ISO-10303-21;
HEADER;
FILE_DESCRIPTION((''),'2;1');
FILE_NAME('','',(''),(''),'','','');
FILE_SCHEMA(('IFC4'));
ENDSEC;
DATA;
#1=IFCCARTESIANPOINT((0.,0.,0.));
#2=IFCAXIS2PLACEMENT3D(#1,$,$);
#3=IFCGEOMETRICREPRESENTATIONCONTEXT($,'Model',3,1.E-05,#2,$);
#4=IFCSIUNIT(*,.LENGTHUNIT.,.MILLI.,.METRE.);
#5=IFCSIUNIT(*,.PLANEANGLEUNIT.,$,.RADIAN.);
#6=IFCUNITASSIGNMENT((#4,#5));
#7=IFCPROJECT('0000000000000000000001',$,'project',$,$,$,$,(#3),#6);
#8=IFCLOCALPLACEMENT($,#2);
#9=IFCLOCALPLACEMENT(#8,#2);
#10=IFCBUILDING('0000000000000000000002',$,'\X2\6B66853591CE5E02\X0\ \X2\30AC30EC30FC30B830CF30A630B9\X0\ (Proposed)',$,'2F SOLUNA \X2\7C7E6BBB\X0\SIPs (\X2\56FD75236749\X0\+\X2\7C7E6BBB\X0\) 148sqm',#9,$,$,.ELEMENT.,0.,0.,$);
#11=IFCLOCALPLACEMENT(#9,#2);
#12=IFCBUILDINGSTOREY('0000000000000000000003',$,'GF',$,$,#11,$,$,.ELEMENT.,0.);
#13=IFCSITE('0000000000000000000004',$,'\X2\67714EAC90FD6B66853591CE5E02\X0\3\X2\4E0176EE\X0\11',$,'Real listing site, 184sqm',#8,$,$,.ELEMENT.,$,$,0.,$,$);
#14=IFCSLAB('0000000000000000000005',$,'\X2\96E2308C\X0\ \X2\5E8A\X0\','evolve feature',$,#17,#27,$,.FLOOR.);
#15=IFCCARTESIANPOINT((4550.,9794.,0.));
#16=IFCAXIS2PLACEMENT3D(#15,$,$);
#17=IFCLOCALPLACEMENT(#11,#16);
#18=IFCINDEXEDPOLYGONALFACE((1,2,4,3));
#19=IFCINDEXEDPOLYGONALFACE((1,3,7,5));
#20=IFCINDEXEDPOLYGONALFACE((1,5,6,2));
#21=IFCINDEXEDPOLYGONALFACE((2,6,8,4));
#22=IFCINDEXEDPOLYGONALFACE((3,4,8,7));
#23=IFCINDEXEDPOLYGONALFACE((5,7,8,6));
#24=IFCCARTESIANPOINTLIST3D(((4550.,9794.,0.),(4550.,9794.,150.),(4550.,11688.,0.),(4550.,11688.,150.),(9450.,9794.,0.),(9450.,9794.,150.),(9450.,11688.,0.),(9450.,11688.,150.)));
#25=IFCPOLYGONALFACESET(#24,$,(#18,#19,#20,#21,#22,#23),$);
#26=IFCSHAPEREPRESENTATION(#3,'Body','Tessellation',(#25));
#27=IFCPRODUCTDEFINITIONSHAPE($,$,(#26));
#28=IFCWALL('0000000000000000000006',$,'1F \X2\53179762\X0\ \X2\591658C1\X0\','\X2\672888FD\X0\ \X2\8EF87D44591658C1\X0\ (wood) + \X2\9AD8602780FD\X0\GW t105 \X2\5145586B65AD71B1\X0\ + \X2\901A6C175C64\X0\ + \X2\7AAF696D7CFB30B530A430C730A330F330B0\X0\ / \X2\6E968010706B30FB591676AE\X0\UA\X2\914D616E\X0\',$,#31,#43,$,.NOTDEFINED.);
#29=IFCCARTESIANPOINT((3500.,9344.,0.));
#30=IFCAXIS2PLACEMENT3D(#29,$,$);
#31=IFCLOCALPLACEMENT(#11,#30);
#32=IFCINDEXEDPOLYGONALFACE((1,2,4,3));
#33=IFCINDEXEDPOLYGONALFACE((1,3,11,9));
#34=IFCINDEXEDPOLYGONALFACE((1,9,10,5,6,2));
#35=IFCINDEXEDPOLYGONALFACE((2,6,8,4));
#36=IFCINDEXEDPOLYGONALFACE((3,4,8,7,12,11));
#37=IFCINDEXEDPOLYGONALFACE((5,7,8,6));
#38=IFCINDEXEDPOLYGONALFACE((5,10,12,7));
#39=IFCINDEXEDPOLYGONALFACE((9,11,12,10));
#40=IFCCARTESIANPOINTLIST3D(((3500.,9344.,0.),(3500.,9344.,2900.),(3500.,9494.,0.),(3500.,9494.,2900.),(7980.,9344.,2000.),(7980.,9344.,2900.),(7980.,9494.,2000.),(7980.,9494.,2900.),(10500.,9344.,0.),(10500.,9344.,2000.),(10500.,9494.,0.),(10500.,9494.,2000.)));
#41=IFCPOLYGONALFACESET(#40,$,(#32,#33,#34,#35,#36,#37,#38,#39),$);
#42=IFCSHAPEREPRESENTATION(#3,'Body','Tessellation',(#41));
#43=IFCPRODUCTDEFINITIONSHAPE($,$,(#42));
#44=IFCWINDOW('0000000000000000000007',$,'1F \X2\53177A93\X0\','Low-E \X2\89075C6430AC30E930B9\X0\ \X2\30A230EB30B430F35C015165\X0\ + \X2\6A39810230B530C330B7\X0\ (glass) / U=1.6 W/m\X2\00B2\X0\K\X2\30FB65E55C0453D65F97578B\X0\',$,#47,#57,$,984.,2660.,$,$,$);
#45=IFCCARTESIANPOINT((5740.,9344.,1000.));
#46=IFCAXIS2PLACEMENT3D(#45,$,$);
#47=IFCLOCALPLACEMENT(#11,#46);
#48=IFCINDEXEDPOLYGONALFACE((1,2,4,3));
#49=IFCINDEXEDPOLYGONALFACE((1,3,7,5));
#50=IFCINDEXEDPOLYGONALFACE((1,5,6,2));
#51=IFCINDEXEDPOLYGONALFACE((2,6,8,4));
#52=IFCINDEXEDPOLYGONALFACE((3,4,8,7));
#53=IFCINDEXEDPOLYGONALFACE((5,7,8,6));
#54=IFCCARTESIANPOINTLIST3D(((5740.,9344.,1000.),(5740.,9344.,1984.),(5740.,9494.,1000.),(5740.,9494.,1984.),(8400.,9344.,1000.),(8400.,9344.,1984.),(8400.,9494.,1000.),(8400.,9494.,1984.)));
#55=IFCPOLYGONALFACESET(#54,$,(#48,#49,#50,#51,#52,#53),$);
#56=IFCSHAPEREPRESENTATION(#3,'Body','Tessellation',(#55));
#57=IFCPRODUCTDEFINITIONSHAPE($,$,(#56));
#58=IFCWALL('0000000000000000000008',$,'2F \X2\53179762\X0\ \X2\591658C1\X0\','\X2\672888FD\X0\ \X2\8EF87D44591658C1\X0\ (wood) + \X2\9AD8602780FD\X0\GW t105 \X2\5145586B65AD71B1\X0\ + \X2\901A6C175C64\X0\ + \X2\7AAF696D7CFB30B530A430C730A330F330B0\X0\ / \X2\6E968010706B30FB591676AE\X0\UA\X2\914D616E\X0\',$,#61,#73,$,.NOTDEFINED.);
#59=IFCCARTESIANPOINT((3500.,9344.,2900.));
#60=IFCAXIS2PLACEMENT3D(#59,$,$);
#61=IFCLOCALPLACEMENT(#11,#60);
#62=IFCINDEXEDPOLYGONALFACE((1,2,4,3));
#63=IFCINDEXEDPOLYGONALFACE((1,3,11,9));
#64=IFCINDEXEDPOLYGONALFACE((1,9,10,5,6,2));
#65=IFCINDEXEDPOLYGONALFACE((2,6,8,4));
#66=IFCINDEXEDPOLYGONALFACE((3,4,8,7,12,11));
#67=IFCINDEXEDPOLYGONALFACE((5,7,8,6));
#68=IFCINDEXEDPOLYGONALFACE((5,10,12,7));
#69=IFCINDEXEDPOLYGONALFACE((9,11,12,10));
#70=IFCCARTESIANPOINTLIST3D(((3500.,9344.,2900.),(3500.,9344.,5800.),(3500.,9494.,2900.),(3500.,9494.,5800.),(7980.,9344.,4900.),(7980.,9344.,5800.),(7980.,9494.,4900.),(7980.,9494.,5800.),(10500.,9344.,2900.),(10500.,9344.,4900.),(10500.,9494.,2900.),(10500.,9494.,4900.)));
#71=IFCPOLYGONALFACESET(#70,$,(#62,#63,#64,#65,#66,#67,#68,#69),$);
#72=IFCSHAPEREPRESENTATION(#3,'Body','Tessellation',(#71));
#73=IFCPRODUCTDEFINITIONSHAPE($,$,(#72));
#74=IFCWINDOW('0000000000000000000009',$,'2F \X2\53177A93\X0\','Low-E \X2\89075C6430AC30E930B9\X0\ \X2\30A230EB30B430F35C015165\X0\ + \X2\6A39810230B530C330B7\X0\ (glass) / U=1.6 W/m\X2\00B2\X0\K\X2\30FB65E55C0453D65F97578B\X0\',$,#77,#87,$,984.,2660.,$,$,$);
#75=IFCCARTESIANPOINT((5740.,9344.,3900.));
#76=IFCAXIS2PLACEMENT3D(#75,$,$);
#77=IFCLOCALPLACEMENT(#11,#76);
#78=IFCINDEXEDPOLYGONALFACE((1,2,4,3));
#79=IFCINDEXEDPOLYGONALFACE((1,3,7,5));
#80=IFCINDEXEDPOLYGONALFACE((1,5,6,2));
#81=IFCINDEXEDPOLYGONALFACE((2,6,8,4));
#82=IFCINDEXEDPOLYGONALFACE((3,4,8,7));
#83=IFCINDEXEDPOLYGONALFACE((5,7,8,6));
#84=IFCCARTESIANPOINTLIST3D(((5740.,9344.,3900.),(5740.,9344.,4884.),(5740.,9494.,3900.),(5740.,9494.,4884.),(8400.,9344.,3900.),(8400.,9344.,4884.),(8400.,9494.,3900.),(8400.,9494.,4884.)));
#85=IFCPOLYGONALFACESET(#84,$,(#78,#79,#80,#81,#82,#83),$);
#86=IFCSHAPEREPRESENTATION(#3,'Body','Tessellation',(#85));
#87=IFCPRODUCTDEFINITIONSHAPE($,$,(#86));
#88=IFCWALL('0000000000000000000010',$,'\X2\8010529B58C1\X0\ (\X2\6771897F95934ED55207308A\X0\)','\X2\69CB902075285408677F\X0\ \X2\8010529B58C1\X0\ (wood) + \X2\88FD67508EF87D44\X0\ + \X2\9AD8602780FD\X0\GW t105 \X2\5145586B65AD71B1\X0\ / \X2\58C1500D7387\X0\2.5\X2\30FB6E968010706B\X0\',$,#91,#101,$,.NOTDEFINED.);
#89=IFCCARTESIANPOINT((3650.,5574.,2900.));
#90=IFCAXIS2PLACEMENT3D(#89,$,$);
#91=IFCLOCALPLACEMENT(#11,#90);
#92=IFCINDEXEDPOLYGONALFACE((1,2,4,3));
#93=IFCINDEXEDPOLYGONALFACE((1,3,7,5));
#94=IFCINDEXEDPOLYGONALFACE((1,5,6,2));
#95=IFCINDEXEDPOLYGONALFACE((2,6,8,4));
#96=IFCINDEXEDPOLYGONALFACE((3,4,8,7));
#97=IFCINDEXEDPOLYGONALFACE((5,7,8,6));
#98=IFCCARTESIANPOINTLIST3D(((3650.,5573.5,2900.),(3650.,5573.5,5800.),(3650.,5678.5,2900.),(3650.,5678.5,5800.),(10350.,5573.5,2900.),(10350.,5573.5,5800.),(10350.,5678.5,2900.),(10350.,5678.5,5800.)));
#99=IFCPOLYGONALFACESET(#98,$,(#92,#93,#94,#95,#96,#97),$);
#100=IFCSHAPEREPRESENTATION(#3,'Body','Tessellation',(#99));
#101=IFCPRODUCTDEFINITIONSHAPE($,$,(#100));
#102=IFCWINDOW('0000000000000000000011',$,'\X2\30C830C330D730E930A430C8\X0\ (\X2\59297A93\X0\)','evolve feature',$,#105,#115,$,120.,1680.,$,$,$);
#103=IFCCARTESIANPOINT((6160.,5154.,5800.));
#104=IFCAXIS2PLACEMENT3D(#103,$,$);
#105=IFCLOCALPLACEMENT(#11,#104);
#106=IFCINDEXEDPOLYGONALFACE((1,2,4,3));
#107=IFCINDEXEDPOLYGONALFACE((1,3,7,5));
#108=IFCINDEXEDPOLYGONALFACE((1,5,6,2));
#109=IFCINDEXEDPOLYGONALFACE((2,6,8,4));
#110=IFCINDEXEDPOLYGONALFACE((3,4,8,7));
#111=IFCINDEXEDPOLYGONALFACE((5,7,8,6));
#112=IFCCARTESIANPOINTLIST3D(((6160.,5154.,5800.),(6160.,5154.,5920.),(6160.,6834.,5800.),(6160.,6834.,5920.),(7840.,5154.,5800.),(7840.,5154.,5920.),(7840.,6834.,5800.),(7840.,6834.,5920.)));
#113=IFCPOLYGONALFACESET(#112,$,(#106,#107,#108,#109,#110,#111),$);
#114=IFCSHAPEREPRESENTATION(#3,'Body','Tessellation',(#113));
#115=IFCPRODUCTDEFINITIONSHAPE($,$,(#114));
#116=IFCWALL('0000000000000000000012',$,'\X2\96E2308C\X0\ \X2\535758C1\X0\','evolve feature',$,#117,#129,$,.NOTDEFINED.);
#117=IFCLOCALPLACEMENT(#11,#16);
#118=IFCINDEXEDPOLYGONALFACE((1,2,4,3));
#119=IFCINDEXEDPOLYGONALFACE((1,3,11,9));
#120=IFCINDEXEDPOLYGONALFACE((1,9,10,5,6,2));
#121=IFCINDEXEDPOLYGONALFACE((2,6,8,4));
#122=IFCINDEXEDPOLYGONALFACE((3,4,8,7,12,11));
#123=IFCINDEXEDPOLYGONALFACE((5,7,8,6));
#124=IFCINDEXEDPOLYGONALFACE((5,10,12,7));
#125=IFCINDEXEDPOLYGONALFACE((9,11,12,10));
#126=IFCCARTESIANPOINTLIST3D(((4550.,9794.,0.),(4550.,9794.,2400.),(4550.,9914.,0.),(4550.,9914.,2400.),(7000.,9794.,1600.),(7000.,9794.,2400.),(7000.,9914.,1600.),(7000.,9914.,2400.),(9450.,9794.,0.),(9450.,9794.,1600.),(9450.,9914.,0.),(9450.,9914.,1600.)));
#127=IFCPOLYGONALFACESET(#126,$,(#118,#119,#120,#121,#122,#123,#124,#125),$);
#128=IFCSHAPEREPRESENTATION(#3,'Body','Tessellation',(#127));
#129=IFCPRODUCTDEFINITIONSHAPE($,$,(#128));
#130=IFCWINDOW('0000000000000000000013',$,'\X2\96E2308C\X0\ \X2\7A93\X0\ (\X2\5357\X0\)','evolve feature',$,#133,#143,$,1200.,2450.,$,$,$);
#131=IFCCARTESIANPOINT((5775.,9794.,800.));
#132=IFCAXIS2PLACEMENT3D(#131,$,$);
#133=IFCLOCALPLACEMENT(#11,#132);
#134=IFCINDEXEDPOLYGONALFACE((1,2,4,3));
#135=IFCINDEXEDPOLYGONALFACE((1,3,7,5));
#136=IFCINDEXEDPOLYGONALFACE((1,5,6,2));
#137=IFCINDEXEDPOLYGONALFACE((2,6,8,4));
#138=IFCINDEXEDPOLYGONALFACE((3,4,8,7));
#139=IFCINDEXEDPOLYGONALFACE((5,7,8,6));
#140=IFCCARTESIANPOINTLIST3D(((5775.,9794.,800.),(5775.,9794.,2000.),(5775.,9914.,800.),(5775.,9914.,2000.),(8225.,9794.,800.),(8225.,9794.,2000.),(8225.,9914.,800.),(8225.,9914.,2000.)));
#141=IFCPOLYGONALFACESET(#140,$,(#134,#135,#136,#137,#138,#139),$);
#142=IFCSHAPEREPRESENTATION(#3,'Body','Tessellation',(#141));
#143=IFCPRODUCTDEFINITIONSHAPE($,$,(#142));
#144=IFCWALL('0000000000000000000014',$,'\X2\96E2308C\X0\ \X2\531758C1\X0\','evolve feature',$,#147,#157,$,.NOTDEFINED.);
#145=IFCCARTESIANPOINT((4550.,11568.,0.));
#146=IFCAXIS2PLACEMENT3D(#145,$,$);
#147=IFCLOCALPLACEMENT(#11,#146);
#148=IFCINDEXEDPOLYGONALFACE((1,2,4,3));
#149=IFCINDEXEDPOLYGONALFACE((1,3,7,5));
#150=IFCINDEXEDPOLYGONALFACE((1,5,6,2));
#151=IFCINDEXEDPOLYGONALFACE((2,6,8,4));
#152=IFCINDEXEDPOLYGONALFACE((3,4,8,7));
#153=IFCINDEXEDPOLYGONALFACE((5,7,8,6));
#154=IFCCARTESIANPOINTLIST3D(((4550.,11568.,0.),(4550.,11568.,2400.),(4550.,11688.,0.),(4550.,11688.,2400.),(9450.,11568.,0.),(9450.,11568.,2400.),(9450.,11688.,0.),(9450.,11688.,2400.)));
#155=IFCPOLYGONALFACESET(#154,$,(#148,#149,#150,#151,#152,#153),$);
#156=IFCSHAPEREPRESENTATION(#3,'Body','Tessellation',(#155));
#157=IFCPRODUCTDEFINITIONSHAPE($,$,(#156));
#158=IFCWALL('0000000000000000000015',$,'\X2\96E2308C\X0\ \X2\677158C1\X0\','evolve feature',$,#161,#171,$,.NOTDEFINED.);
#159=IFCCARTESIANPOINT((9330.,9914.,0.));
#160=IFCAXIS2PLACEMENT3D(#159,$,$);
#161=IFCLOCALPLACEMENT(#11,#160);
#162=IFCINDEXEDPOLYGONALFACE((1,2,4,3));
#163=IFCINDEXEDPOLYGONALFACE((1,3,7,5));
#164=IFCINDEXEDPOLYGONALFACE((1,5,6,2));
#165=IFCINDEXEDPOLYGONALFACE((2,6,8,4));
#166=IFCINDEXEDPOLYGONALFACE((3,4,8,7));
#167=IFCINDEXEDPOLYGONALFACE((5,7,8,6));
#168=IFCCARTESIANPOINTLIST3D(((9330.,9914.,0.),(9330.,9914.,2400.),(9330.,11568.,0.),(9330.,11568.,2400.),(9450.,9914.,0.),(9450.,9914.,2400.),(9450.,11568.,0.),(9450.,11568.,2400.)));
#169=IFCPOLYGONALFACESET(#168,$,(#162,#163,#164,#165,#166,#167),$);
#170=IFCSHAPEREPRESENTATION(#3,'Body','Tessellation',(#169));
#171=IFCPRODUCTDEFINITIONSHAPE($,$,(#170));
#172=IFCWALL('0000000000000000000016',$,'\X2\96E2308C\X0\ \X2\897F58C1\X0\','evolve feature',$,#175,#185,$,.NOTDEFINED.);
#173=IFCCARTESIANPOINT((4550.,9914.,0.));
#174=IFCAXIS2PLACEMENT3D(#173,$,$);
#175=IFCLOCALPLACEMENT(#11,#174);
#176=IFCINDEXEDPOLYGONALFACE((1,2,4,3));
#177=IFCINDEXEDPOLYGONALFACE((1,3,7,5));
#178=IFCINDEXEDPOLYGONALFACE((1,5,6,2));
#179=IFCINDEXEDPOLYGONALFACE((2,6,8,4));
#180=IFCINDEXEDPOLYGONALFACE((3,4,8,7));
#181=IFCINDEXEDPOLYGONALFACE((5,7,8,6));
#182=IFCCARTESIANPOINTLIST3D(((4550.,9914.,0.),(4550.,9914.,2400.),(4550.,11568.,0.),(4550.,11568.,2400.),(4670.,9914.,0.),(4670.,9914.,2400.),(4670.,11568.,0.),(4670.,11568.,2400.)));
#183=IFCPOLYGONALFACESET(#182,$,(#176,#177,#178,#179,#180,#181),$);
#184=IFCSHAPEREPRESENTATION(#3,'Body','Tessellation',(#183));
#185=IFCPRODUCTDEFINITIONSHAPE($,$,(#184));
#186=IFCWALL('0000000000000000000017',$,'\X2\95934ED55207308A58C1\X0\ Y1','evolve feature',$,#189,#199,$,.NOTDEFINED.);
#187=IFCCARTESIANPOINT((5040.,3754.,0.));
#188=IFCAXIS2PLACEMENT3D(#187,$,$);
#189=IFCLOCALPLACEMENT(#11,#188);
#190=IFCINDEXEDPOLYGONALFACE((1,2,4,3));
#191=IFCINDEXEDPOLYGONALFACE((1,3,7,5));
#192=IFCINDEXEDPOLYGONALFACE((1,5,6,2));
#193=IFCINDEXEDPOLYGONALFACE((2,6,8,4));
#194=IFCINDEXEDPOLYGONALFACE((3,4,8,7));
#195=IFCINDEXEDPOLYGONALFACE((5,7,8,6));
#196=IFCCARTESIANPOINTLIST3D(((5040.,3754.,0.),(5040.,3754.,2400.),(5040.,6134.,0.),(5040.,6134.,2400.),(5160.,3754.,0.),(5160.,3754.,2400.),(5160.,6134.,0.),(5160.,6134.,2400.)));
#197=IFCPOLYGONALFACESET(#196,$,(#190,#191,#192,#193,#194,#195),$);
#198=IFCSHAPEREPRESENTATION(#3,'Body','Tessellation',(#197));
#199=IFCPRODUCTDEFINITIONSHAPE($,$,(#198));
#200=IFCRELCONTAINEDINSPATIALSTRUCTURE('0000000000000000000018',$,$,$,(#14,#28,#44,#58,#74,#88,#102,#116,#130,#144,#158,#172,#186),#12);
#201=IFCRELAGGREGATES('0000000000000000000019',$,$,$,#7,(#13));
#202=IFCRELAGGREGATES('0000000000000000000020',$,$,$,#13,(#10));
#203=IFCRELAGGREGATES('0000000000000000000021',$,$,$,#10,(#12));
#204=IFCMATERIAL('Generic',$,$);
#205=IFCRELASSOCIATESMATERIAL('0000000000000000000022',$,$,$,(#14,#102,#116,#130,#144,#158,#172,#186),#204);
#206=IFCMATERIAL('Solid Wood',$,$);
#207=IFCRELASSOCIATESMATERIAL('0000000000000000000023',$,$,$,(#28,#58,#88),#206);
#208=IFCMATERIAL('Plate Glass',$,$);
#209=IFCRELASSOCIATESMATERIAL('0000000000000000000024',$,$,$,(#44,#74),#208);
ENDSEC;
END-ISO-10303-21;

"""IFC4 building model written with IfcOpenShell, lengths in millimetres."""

from ifc_helpers import new_model, si_unit, frame, frame_2d, origin, place, context, project, spatial, rectangle, extrude, material, element, fill, save


model = new_model("IFC4")

# Units and contexts
model_context = context("Model", 3, precision=1e-05, world=origin())
ifc_project = project(units=[si_unit("LENGTHUNIT", "METRE", prefix="MILLI"), si_unit("PLANEANGLEUNIT", "RADIAN")], contexts=[model_context])

# Site, building, storey
site_placement = place(None, origin())
site = spatial("IfcSite", under=ifc_project, at=site_placement, Name="東京都武蔵野市3丁目11", ObjectType="Real listing site, 184sqm", CompositionType="ELEMENT", RefElevation=0.0)
building_placement = place(site_placement, origin())
building = spatial("IfcBuilding", under=site, at=building_placement, Name="武蔵野市 ガレージハウス (Proposed)", ObjectType="2F SOLUNA 籾殻SIPs (国産杉+籾殻) 148sqm", CompositionType="ELEMENT", ElevationOfRefHeight=0.0, ElevationOfTerrain=0.0)
storey_placement = place(building_placement, origin())
storey = spatial("IfcBuildingStorey", under=building, at=storey_placement, Name="GF", CompositionType="ELEMENT", Elevation=0.0)

# Slab
ifc_material_1 = material(Name="Generic")
slab_placement = place(storey_placement, frame((4550.0, 9794.0, 0.0)))
element("IfcSlab", 1, at=slab_placement, inside=storey, material=ifc_material_1, Name="離れ 床", Description="evolve feature", PredefinedType="FLOOR", context=model_context, shape_type="SweptSolid", body=[
    extrude(rectangle(XDim=4900.0, YDim=1894.0, at=frame_2d((2450.0, 947.0))), frame((4550.0, 9794.0, 0.0)), (0.0, 0.0, 1.0), 150.0),
])

# Wall, opening, window
ifc_material_2 = material(Name="Solid Wood")
wall_1_placement = place(storey_placement, frame((3500.0, 9344.0, 0.0)))
wall_1 = element("IfcWall", 2, at=wall_1_placement, inside=storey, material=ifc_material_2, Name="1F 北面 外壁", Description="木製 軸組外壁 (wood) + 高性能GW t105 充填断熱 + 通気層 + 窯業系サイディング / 準耐火・外皮UA配慮", PredefinedType="NOTDEFINED", context=model_context, shape_type="SweptSolid", body=[
    extrude(rectangle(XDim=7000.0, YDim=150.0, at=frame_2d((3500.0, 75.0))), frame((3500.0, 9344.0, 0.0)), (0.0, 0.0, 1.0), 2900.0),
])
opening_1_placement = place(storey_placement, frame((5740.0, 9344.0, 1000.0)))
opening_1 = element("IfcOpeningElement", 3, at=opening_1_placement, cuts=wall_1, PredefinedType="NOTDEFINED", context=model_context, shape_type="SweptSolid", body=[
    extrude(rectangle(XDim=2660.0, YDim=150.0, at=frame_2d((1330.0, 75.0))), frame((5740.0, 9344.0, 1000.0)), (0.0, 0.0, 1.0), 984.0),
])
ifc_material_3 = material(Name="Plate Glass")
window_1_placement = place(storey_placement, frame((5740.0, 9344.0, 1000.0)))
window_1 = element("IfcWindow", 4, at=window_1_placement, inside=storey, material=ifc_material_3, Name="1F 北窓", Description="Low-E 複層ガラス アルゴン封入 + 樹脂サッシ (glass) / U=1.6 W/m²K・日射取得型", OverallHeight=984.0, OverallWidth=2660.0, context=model_context, shape_type="SweptSolid", body=[
    extrude(rectangle(XDim=2660.0, YDim=150.0, at=frame_2d((1330.0, 75.0))), frame((5740.0, 9344.0, 1000.0)), (0.0, 0.0, 1.0), 984.0),
])
fill(opening_1, window_1)

# Wall, opening, window
wall_2_placement = place(storey_placement, frame((3500.0, 9344.0, 2900.0)))
wall_2 = element("IfcWall", 5, at=wall_2_placement, inside=storey, material=ifc_material_2, Name="2F 北面 外壁", Description="木製 軸組外壁 (wood) + 高性能GW t105 充填断熱 + 通気層 + 窯業系サイディング / 準耐火・外皮UA配慮", PredefinedType="NOTDEFINED", context=model_context, shape_type="SweptSolid", body=[
    extrude(rectangle(XDim=7000.0, YDim=150.0, at=frame_2d((3500.0, 75.0))), frame((3500.0, 9344.0, 2900.0)), (0.0, 0.0, 1.0), 2900.0),
])
opening_2_placement = place(storey_placement, frame((5740.0, 9344.0, 3900.0)))
opening_2 = element("IfcOpeningElement", 6, at=opening_2_placement, cuts=wall_2, PredefinedType="NOTDEFINED", context=model_context, shape_type="SweptSolid", body=[
    extrude(rectangle(XDim=2660.0, YDim=150.0, at=frame_2d((1330.0, 75.0))), frame((5740.0, 9344.0, 3900.0)), (0.0, 0.0, 1.0), 984.0),
])
window_2_placement = place(storey_placement, frame((5740.0, 9344.0, 3900.0)))
window_2 = element("IfcWindow", 7, at=window_2_placement, inside=storey, material=ifc_material_3, Name="2F 北窓", Description="Low-E 複層ガラス アルゴン封入 + 樹脂サッシ (glass) / U=1.6 W/m²K・日射取得型", OverallHeight=984.0, OverallWidth=2660.0, context=model_context, shape_type="SweptSolid", body=[
    extrude(rectangle(XDim=2660.0, YDim=150.0, at=frame_2d((1330.0, 75.0))), frame((5740.0, 9344.0, 3900.0)), (0.0, 0.0, 1.0), 984.0),
])
fill(opening_2, window_2)

# Wall
wall_3_placement = place(storey_placement, frame((3650.0, 5574.0, 2900.0)))
element("IfcWall", 8, at=wall_3_placement, inside=storey, material=ifc_material_2, Name="耐力壁 (東西間仕切り)", Description="構造用合板 耐力壁 (wood) + 製材軸組 + 高性能GW t105 充填断熱 / 壁倍率2.5・準耐火", PredefinedType="NOTDEFINED", context=model_context, shape_type="SweptSolid", body=[
    extrude(rectangle(XDim=6700.0, YDim=105.0, at=frame_2d((3350.0, 52.0))), frame((3650.0, 5574.0, 2900.0)), (0.0, 0.0, 1.0), 2900.0),
])

# Window
window_3_placement = place(storey_placement, frame((6160.0, 5154.0, 5800.0)))
element("IfcWindow", 9, at=window_3_placement, inside=storey, material=ifc_material_1, Name="トップライト (天窓)", Description="evolve feature", OverallHeight=120.0, OverallWidth=1680.0, context=model_context, shape_type="SweptSolid", body=[
    extrude(rectangle(XDim=1680.0, YDim=1680.0, at=frame_2d((840.0, 840.0))), frame((6160.0, 5154.0, 5800.0)), (0.0, 0.0, 1.0), 120.0),
])

# Wall, opening, window
wall_4_placement = place(storey_placement, frame((4550.0, 9794.0, 0.0)))
wall_4 = element("IfcWall", 10, at=wall_4_placement, inside=storey, material=ifc_material_1, Name="離れ 南壁", Description="evolve feature", PredefinedType="NOTDEFINED", context=model_context, shape_type="SweptSolid", body=[
    extrude(rectangle(XDim=4900.0, YDim=120.0, at=frame_2d((2450.0, 60.0))), frame((4550.0, 9794.0, 0.0)), (0.0, 0.0, 1.0), 2400.0),
])
opening_3_placement = place(storey_placement, frame((5775.0, 9794.0, 800.0)))
opening_3 = element("IfcOpeningElement", 11, at=opening_3_placement, cuts=wall_4, PredefinedType="NOTDEFINED", context=model_context, shape_type="SweptSolid", body=[
    extrude(rectangle(XDim=2450.0, YDim=120.0, at=frame_2d((1225.0, 60.0))), frame((5775.0, 9794.0, 800.0)), (0.0, 0.0, 1.0), 1200.0),
])
window_4_placement = place(storey_placement, frame((5775.0, 9794.0, 800.0)))
window_4 = element("IfcWindow", 12, at=window_4_placement, inside=storey, material=ifc_material_1, Name="離れ 窓 (南)", Description="evolve feature", OverallHeight=1200.0, OverallWidth=2450.0, context=model_context, shape_type="SweptSolid", body=[
    extrude(rectangle(XDim=2450.0, YDim=120.0, at=frame_2d((1225.0, 60.0))), frame((5775.0, 9794.0, 800.0)), (0.0, 0.0, 1.0), 1200.0),
])
fill(opening_3, window_4)

# Walls
wall_5_placement = place(storey_placement, frame((4550.0, 11568.0, 0.0)))
element("IfcWall", 13, at=wall_5_placement, inside=storey, material=ifc_material_1, Name="離れ 北壁", Description="evolve feature", PredefinedType="NOTDEFINED", context=model_context, shape_type="SweptSolid", body=[
    extrude(rectangle(XDim=4900.0, YDim=120.0, at=frame_2d((2450.0, 60.0))), frame((4550.0, 11568.0, 0.0)), (0.0, 0.0, 1.0), 2400.0),
])
wall_6_placement = place(storey_placement, frame((9330.0, 9914.0, 0.0)))
element("IfcWall", 14, at=wall_6_placement, inside=storey, material=ifc_material_1, Name="離れ 東壁", Description="evolve feature", PredefinedType="NOTDEFINED", context=model_context, shape_type="SweptSolid", body=[
    extrude(rectangle(XDim=120.0, YDim=1654.0, at=frame_2d((60.0, 827.0))), frame((9330.0, 9914.0, 0.0)), (0.0, 0.0, 1.0), 2400.0),
])
wall_7_placement = place(storey_placement, frame((4550.0, 9914.0, 0.0)))
element("IfcWall", 15, at=wall_7_placement, inside=storey, material=ifc_material_1, Name="離れ 西壁", Description="evolve feature", PredefinedType="NOTDEFINED", context=model_context, shape_type="SweptSolid", body=[
    extrude(rectangle(XDim=120.0, YDim=1654.0, at=frame_2d((60.0, 827.0))), frame((4550.0, 9914.0, 0.0)), (0.0, 0.0, 1.0), 2400.0),
])
wall_8_placement = place(storey_placement, frame((5040.0, 3754.0, 0.0)))
element("IfcWall", 16, at=wall_8_placement, inside=storey, material=ifc_material_1, Name="間仕切り壁 Y1", Description="evolve feature", PredefinedType="NOTDEFINED", context=model_context, shape_type="SweptSolid", body=[
    extrude(rectangle(XDim=120.0, YDim=2380.0, at=frame_2d((60.0, 1190.0))), frame((5040.0, 3754.0, 0.0)), (0.0, 0.0, 1.0), 2400.0),
])

save(model, "model.ifc")
